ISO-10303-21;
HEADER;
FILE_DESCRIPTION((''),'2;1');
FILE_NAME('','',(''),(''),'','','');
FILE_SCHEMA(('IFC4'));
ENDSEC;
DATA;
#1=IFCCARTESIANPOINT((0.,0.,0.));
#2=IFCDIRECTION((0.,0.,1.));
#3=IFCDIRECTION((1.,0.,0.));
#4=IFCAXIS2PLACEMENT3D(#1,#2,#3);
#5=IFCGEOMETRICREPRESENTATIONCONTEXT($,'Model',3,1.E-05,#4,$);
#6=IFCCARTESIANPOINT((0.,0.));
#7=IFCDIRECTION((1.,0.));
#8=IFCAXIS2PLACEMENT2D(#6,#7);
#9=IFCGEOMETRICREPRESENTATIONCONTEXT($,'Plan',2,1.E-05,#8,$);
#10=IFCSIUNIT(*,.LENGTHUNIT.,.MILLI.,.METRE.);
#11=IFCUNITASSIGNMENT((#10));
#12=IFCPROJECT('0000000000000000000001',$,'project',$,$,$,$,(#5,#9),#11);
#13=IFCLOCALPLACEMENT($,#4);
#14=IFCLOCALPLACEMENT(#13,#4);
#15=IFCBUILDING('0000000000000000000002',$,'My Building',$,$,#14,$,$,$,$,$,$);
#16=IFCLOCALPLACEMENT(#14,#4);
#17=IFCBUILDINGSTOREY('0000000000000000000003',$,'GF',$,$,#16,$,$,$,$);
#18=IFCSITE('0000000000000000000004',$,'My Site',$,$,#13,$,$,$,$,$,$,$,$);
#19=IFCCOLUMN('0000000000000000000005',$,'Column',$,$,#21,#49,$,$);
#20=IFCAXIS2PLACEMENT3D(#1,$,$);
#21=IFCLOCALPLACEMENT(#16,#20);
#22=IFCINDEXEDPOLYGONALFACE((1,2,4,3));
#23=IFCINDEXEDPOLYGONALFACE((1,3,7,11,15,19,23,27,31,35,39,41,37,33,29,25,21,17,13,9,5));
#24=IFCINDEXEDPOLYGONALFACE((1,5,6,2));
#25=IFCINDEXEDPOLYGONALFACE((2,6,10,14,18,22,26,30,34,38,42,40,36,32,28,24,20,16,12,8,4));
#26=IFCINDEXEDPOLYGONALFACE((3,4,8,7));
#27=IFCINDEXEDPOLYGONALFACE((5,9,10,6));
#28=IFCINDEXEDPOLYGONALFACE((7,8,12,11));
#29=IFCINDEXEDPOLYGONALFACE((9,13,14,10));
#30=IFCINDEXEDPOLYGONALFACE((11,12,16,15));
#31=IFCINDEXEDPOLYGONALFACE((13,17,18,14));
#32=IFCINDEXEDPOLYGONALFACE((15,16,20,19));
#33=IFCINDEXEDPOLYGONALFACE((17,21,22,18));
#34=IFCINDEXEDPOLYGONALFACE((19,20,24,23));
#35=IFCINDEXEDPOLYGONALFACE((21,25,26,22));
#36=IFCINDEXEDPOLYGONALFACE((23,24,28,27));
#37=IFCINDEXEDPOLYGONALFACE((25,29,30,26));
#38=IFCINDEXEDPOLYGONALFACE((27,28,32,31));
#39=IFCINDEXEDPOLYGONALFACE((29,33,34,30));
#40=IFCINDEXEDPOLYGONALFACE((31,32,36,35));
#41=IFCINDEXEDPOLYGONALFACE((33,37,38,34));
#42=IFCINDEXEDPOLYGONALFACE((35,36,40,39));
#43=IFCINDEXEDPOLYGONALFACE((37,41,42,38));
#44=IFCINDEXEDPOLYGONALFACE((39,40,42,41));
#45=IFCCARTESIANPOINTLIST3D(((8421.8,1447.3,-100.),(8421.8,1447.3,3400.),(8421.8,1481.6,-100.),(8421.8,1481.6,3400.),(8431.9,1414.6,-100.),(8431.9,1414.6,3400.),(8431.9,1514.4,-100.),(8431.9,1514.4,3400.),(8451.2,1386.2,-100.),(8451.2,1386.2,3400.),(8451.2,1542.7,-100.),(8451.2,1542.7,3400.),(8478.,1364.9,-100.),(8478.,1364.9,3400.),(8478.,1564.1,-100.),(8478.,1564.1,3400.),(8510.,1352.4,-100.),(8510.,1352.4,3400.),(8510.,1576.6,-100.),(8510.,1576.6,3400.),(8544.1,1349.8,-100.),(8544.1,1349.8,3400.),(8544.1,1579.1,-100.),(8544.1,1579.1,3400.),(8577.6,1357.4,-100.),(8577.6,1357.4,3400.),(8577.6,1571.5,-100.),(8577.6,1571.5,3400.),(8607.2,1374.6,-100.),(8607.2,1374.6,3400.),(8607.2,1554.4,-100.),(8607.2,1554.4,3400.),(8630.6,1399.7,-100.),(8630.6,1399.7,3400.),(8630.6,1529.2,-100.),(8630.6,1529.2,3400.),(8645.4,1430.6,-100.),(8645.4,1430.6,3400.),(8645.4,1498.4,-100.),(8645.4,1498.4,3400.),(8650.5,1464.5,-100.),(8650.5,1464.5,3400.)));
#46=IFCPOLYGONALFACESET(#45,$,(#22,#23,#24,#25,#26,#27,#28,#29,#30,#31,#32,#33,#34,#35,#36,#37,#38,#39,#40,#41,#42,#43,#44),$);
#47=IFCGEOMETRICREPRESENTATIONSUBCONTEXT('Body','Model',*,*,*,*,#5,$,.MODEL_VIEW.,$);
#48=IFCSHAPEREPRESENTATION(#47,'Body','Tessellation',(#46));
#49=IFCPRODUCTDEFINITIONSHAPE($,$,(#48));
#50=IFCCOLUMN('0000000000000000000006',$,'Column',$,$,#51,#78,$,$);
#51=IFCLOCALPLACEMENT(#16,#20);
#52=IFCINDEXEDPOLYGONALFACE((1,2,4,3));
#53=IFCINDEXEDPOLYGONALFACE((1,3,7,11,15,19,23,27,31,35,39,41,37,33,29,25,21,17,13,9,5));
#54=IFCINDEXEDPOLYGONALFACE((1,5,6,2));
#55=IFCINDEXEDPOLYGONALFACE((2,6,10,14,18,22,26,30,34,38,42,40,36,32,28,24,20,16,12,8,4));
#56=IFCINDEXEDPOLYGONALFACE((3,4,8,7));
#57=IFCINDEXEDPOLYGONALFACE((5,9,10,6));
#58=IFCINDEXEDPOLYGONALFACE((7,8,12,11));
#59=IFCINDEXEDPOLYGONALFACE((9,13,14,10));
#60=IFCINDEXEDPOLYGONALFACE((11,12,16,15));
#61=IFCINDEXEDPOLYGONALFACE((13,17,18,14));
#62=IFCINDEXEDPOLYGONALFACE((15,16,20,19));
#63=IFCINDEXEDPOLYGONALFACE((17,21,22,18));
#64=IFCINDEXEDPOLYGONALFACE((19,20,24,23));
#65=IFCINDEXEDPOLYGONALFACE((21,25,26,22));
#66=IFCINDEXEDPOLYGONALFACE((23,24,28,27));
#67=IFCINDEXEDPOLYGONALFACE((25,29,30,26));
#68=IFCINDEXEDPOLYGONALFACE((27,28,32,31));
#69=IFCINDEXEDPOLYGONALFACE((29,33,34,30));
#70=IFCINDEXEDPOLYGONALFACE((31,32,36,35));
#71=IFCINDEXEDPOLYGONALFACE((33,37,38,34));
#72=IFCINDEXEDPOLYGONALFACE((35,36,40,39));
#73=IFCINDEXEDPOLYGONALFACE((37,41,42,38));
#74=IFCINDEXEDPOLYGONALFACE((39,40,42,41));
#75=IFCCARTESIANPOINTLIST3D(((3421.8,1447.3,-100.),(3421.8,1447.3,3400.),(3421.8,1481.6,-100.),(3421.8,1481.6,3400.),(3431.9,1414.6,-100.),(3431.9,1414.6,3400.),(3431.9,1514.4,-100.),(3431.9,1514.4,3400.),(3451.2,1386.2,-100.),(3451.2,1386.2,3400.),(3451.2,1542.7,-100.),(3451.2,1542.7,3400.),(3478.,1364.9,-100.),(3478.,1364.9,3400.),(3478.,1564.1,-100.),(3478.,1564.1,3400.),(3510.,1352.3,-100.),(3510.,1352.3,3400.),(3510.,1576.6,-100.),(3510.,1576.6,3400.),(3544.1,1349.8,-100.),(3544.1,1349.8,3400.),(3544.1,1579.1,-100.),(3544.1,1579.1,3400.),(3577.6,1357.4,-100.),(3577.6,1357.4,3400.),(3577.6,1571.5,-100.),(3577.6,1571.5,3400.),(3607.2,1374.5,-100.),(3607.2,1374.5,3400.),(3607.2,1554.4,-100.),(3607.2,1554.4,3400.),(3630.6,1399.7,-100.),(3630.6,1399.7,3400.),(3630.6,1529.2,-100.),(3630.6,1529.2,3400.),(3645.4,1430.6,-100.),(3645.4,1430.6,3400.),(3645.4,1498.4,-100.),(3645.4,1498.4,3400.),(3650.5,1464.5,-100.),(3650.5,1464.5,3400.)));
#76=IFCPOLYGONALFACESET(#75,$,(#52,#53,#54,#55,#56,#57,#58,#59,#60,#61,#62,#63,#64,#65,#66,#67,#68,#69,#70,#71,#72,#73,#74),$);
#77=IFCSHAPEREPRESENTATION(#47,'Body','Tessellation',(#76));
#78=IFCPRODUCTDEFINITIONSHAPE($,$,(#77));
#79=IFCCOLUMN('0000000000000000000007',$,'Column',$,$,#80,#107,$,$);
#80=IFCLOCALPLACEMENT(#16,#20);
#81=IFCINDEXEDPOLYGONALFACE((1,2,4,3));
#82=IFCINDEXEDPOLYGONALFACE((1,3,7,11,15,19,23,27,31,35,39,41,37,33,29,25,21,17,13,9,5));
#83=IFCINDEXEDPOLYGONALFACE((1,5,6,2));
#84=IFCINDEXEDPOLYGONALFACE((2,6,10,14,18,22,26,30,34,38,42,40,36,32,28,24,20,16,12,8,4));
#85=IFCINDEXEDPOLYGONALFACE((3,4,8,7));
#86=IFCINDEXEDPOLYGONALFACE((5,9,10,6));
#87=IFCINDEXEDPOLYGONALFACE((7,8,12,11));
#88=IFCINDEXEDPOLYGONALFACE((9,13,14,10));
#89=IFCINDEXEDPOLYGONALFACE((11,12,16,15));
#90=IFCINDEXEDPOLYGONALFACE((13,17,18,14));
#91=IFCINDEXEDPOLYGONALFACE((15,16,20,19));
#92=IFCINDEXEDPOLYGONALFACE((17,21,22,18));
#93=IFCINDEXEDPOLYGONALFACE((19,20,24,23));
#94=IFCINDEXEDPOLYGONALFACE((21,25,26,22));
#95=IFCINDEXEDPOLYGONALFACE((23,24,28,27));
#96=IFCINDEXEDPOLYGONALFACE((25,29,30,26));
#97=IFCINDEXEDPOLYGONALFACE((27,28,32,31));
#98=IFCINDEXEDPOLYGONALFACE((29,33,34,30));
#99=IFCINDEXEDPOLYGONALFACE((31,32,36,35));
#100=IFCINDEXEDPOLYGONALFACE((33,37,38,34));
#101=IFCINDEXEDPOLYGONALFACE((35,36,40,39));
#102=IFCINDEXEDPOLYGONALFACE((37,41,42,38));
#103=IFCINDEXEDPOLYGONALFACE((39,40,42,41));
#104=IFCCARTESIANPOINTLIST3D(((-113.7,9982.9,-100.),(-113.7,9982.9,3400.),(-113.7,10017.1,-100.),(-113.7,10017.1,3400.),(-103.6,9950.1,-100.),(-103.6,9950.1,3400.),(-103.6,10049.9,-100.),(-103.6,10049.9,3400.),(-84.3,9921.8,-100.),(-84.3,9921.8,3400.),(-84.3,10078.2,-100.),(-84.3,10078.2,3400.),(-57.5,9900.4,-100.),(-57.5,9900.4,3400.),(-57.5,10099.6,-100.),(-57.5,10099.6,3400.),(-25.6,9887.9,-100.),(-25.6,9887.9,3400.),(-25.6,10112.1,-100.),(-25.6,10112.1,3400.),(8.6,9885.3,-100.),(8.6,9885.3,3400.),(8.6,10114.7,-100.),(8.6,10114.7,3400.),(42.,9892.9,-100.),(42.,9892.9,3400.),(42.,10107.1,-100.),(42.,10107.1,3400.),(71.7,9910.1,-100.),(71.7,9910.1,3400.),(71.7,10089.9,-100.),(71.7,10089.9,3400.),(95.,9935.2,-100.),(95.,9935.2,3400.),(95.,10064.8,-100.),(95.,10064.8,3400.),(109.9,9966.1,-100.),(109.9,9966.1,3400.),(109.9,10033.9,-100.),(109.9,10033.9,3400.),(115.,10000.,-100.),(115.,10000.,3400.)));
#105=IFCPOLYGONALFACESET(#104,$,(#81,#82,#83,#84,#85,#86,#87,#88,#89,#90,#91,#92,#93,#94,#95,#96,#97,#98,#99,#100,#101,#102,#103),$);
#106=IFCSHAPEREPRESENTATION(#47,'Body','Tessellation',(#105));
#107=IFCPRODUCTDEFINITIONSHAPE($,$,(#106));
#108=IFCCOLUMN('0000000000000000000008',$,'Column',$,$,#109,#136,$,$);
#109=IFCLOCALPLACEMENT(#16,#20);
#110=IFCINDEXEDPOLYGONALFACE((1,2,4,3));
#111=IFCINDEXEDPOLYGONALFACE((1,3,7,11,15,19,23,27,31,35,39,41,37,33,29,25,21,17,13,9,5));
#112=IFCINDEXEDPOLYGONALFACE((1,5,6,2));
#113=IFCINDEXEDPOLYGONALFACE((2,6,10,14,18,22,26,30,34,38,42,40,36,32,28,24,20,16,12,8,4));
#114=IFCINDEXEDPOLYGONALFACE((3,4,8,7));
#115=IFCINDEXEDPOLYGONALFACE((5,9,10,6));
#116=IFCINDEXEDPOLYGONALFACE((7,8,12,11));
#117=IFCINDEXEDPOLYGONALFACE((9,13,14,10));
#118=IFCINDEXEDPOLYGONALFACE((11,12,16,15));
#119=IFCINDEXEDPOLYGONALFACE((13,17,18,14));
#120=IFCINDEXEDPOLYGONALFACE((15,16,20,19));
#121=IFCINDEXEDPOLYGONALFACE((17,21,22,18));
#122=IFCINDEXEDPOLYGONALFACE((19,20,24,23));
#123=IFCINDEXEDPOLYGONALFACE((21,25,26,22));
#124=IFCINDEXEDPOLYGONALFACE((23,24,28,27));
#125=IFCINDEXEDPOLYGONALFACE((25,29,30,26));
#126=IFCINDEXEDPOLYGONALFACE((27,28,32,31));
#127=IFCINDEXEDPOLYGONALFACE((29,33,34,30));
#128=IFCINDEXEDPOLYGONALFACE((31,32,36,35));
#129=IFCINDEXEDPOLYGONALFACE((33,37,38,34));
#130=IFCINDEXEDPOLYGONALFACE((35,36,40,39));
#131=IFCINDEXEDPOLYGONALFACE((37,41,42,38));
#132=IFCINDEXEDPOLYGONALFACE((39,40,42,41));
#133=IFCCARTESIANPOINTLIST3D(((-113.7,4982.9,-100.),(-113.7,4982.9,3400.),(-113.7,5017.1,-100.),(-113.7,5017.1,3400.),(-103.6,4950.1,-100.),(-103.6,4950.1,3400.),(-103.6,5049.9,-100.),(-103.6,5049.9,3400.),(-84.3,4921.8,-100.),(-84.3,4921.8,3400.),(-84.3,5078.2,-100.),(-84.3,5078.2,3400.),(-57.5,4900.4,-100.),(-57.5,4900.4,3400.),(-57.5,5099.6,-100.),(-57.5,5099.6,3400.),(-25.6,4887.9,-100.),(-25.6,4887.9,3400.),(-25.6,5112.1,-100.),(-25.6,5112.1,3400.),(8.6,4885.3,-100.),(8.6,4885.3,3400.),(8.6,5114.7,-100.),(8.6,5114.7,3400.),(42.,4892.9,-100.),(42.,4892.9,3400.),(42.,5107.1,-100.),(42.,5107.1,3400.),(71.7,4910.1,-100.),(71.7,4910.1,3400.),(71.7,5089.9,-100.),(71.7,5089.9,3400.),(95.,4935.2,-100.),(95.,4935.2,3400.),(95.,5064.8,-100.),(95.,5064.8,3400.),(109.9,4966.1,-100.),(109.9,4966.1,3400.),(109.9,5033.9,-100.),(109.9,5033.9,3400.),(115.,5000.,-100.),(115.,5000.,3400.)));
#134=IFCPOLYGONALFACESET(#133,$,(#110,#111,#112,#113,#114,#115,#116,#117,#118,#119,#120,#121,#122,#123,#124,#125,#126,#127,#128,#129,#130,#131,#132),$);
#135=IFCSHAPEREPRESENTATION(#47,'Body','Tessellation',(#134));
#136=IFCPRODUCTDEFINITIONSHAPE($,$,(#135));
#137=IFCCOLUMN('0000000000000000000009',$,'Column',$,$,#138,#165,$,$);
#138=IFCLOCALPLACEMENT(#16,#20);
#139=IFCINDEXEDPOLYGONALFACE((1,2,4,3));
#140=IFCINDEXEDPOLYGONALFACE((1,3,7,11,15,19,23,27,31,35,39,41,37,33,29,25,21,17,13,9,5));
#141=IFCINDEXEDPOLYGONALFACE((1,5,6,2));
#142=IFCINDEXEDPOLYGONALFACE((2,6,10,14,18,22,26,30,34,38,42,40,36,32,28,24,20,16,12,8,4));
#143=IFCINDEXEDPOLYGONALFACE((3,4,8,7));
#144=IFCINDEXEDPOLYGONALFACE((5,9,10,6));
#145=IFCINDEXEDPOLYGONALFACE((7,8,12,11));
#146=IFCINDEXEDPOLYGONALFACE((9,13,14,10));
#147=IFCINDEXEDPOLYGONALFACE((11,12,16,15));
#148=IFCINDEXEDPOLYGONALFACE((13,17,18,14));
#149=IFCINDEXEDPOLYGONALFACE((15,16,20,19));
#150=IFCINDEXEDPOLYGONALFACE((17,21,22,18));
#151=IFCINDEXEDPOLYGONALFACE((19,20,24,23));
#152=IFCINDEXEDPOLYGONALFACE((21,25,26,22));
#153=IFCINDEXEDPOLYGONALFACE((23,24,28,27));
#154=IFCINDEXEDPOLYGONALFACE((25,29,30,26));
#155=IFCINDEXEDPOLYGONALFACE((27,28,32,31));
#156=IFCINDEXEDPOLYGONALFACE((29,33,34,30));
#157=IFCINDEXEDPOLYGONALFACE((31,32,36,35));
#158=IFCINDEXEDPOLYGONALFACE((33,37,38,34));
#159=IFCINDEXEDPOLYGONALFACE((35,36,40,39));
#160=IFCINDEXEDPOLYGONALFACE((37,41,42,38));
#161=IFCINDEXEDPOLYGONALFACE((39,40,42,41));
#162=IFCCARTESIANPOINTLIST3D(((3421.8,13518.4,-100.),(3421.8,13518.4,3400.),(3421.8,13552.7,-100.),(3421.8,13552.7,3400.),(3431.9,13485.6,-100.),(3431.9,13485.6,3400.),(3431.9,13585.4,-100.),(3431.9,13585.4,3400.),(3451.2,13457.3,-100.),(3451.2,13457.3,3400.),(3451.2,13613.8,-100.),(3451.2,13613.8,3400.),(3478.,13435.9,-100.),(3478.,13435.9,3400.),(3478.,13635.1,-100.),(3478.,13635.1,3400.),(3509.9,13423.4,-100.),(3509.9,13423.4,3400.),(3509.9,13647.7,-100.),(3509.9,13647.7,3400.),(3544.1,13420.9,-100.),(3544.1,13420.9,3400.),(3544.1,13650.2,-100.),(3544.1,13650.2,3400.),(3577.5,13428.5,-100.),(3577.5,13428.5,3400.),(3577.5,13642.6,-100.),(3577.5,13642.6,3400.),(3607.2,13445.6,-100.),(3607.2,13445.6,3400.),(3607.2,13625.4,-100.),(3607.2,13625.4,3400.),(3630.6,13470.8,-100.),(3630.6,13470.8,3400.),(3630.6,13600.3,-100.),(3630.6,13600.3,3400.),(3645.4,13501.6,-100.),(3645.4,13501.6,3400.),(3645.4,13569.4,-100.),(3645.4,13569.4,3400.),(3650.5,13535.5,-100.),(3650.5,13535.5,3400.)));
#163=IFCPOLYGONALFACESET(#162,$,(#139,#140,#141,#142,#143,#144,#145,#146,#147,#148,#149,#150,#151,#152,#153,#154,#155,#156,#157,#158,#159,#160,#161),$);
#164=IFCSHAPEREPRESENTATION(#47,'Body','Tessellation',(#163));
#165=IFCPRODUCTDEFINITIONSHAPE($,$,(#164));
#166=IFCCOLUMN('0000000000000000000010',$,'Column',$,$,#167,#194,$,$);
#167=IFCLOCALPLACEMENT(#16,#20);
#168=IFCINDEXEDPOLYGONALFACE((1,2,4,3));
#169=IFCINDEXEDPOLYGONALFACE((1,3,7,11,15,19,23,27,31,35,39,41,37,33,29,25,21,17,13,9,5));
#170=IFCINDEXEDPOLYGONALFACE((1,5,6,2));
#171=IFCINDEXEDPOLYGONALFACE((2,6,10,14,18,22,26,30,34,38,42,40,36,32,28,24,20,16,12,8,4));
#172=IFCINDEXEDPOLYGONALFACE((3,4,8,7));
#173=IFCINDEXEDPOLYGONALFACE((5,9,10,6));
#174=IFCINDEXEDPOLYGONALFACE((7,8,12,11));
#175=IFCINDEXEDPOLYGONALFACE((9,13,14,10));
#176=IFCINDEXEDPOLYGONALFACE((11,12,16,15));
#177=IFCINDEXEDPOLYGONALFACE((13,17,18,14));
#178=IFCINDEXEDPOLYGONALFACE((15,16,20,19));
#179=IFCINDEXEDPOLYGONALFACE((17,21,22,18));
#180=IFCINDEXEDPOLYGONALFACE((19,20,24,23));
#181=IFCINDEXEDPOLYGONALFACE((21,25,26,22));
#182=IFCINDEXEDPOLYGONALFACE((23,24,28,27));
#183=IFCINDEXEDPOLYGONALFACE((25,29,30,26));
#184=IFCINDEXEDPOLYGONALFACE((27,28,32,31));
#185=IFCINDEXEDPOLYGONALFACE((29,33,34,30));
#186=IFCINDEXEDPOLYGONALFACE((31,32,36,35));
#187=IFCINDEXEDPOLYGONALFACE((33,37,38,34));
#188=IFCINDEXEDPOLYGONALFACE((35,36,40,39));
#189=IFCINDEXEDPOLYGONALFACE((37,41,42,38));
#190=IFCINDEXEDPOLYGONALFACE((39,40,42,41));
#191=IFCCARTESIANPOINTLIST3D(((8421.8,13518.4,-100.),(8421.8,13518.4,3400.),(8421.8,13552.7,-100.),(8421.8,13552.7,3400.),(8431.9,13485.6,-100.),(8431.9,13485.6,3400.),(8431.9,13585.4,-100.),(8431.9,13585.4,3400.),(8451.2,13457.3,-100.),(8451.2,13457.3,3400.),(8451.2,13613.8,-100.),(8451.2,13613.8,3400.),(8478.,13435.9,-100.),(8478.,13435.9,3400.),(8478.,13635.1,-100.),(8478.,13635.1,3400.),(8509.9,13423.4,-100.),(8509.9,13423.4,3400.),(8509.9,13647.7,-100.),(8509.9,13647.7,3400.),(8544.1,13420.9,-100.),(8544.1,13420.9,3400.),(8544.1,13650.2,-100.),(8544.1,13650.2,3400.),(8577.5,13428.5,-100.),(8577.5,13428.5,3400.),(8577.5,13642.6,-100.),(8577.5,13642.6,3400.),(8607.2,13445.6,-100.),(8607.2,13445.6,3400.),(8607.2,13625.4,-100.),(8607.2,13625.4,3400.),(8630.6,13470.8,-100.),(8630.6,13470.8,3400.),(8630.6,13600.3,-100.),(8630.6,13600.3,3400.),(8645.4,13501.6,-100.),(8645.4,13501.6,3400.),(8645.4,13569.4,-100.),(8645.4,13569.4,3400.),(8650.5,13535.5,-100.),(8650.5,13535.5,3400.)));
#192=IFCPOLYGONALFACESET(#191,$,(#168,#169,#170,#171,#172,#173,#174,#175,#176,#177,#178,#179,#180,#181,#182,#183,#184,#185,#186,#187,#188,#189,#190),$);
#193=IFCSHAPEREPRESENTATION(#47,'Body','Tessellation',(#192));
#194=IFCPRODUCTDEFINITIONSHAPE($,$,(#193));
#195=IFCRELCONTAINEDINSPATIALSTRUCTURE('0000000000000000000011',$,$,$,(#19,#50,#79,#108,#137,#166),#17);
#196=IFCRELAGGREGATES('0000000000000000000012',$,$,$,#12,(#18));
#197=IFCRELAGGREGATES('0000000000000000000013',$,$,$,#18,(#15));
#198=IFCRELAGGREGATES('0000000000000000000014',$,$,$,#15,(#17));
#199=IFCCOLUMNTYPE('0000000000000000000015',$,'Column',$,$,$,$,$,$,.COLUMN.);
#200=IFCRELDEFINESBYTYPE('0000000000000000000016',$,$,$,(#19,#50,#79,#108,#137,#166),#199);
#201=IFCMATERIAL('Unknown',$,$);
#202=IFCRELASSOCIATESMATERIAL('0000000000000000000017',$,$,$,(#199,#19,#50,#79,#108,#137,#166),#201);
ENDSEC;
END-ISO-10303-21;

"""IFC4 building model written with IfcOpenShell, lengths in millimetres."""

from ifc_helpers import new_model, si_unit, frame, origin_with_axes, origin_2d_with_axis, place, context, subcontext, project, spatial, circle, extrude, material, material_profile, profile_set, profile_usage, type_object, element, save


model = new_model("IFC4")

# Units and contexts
model_context = context("Model", 3, precision=1e-05, world=origin_with_axes())
plan_context = context("Plan", 2, precision=1e-05, world=origin_2d_with_axis())
body_context_1 = subcontext(model_context, "Body", "Model", "MODEL_VIEW")
ifc_project = project(units=[si_unit("LENGTHUNIT", "METRE", prefix="MILLI")], contexts=[model_context, plan_context])

# Site, building, storey
site_placement = place(None, origin_with_axes())
site = spatial("IfcSite", under=ifc_project, at=site_placement, Name="My Site")
building_placement = place(site_placement, origin_with_axes())
building = spatial("IfcBuilding", under=site, at=building_placement, Name="My Building")
storey_placement = place(building_placement, origin_with_axes())
storey = spatial("IfcBuildingStorey", under=building, at=storey_placement, Name="GF")

# Columns
ifc_material = material(Name="Unknown")
ifc_material_profile_1 = material_profile(ifc_material, circle(Radius=115.0))
ifc_profile_set_1 = profile_set([ifc_material_profile_1])
ifc_profile_usage_1 = profile_usage(ifc_profile_set_1, cardinal=5)
column_type = type_object("IfcColumnType", Name="Column", PredefinedType="COLUMN", material=ifc_profile_set_1)
column_1_placement = place(storey_placement, frame((8535.5, 1464.5, -100.0), z_axis=(0.0, 0.0, 1.0), x_axis=(1.0, 0.0, 0.0)))
element("IfcColumn", 1, at=column_1_placement, inside=storey, type_object=column_type, material=ifc_profile_usage_1, Name="Column", context=body_context_1, shape_type="SweptSolid", body=[
    extrude(circle(Radius=115.0), origin_with_axes(), (0.0, 0.0, 1.0), 3500.0),
])
ifc_profile_usage_2 = profile_usage(ifc_profile_set_1, cardinal=5)
column_2_placement = place(storey_placement, frame((3535.5, 1464.5, -100.0), z_axis=(0.0, 0.0, 1.0), x_axis=(1.0, 0.0, 0.0)))
element("IfcColumn", 2, at=column_2_placement, inside=storey, type_object=column_type, material=ifc_profile_usage_2, Name="Column", context=body_context_1, shape_type="SweptSolid", body=[
    extrude(circle(Radius=115.0), origin_with_axes(), (0.0, 0.0, 1.0), 3500.0),
])
ifc_profile_usage_3 = profile_usage(ifc_profile_set_1, cardinal=5)
column_3_placement = place(storey_placement, frame((0.0, 10000.0, -100.0), z_axis=(0.0, 0.0, 1.0), x_axis=(1.0, 0.0, 0.0)))
element("IfcColumn", 3, at=column_3_placement, inside=storey, type_object=column_type, material=ifc_profile_usage_3, Name="Column", context=body_context_1, shape_type="SweptSolid", body=[
    extrude(circle(Radius=115.0), origin_with_axes(), (0.0, 0.0, 1.0), 3500.0),
])
ifc_profile_usage_4 = profile_usage(ifc_profile_set_1, cardinal=5)
column_4_placement = place(storey_placement, frame((0.0, 5000.0, -100.0), z_axis=(0.0, 0.0, 1.0), x_axis=(1.0, 0.0, 0.0)))
element("IfcColumn", 4, at=column_4_placement, inside=storey, type_object=column_type, material=ifc_profile_usage_4, Name="Column", context=body_context_1, shape_type="SweptSolid", body=[
    extrude(circle(Radius=115.0), origin_with_axes(), (0.0, 0.0, 1.0), 3500.0),
])
ifc_profile_usage_5 = profile_usage(ifc_profile_set_1, cardinal=5)
column_5_placement = place(storey_placement, frame((3535.5, 13535.5, -100.0), z_axis=(0.0, 0.0, 1.0), x_axis=(1.0, 0.0, 0.0)))
element("IfcColumn", 5, at=column_5_placement, inside=storey, type_object=column_type, material=ifc_profile_usage_5, Name="Column", context=body_context_1, shape_type="SweptSolid", body=[
    extrude(circle(Radius=115.0), origin_with_axes(), (0.0, 0.0, 1.0), 3500.0),
])
ifc_profile_usage_6 = profile_usage(ifc_profile_set_1, cardinal=5)
column_6_placement = place(storey_placement, frame((8535.5, 13535.5, -100.0), z_axis=(0.0, 0.0, 1.0), x_axis=(1.0, 0.0, 0.0)))
element("IfcColumn", 6, at=column_6_placement, inside=storey, type_object=column_type, material=ifc_profile_usage_6, Name="Column", context=body_context_1, shape_type="SweptSolid", body=[
    extrude(circle(Radius=115.0), origin_with_axes(), (0.0, 0.0, 1.0), 3500.0),
])

save(model, "model.ifc")
